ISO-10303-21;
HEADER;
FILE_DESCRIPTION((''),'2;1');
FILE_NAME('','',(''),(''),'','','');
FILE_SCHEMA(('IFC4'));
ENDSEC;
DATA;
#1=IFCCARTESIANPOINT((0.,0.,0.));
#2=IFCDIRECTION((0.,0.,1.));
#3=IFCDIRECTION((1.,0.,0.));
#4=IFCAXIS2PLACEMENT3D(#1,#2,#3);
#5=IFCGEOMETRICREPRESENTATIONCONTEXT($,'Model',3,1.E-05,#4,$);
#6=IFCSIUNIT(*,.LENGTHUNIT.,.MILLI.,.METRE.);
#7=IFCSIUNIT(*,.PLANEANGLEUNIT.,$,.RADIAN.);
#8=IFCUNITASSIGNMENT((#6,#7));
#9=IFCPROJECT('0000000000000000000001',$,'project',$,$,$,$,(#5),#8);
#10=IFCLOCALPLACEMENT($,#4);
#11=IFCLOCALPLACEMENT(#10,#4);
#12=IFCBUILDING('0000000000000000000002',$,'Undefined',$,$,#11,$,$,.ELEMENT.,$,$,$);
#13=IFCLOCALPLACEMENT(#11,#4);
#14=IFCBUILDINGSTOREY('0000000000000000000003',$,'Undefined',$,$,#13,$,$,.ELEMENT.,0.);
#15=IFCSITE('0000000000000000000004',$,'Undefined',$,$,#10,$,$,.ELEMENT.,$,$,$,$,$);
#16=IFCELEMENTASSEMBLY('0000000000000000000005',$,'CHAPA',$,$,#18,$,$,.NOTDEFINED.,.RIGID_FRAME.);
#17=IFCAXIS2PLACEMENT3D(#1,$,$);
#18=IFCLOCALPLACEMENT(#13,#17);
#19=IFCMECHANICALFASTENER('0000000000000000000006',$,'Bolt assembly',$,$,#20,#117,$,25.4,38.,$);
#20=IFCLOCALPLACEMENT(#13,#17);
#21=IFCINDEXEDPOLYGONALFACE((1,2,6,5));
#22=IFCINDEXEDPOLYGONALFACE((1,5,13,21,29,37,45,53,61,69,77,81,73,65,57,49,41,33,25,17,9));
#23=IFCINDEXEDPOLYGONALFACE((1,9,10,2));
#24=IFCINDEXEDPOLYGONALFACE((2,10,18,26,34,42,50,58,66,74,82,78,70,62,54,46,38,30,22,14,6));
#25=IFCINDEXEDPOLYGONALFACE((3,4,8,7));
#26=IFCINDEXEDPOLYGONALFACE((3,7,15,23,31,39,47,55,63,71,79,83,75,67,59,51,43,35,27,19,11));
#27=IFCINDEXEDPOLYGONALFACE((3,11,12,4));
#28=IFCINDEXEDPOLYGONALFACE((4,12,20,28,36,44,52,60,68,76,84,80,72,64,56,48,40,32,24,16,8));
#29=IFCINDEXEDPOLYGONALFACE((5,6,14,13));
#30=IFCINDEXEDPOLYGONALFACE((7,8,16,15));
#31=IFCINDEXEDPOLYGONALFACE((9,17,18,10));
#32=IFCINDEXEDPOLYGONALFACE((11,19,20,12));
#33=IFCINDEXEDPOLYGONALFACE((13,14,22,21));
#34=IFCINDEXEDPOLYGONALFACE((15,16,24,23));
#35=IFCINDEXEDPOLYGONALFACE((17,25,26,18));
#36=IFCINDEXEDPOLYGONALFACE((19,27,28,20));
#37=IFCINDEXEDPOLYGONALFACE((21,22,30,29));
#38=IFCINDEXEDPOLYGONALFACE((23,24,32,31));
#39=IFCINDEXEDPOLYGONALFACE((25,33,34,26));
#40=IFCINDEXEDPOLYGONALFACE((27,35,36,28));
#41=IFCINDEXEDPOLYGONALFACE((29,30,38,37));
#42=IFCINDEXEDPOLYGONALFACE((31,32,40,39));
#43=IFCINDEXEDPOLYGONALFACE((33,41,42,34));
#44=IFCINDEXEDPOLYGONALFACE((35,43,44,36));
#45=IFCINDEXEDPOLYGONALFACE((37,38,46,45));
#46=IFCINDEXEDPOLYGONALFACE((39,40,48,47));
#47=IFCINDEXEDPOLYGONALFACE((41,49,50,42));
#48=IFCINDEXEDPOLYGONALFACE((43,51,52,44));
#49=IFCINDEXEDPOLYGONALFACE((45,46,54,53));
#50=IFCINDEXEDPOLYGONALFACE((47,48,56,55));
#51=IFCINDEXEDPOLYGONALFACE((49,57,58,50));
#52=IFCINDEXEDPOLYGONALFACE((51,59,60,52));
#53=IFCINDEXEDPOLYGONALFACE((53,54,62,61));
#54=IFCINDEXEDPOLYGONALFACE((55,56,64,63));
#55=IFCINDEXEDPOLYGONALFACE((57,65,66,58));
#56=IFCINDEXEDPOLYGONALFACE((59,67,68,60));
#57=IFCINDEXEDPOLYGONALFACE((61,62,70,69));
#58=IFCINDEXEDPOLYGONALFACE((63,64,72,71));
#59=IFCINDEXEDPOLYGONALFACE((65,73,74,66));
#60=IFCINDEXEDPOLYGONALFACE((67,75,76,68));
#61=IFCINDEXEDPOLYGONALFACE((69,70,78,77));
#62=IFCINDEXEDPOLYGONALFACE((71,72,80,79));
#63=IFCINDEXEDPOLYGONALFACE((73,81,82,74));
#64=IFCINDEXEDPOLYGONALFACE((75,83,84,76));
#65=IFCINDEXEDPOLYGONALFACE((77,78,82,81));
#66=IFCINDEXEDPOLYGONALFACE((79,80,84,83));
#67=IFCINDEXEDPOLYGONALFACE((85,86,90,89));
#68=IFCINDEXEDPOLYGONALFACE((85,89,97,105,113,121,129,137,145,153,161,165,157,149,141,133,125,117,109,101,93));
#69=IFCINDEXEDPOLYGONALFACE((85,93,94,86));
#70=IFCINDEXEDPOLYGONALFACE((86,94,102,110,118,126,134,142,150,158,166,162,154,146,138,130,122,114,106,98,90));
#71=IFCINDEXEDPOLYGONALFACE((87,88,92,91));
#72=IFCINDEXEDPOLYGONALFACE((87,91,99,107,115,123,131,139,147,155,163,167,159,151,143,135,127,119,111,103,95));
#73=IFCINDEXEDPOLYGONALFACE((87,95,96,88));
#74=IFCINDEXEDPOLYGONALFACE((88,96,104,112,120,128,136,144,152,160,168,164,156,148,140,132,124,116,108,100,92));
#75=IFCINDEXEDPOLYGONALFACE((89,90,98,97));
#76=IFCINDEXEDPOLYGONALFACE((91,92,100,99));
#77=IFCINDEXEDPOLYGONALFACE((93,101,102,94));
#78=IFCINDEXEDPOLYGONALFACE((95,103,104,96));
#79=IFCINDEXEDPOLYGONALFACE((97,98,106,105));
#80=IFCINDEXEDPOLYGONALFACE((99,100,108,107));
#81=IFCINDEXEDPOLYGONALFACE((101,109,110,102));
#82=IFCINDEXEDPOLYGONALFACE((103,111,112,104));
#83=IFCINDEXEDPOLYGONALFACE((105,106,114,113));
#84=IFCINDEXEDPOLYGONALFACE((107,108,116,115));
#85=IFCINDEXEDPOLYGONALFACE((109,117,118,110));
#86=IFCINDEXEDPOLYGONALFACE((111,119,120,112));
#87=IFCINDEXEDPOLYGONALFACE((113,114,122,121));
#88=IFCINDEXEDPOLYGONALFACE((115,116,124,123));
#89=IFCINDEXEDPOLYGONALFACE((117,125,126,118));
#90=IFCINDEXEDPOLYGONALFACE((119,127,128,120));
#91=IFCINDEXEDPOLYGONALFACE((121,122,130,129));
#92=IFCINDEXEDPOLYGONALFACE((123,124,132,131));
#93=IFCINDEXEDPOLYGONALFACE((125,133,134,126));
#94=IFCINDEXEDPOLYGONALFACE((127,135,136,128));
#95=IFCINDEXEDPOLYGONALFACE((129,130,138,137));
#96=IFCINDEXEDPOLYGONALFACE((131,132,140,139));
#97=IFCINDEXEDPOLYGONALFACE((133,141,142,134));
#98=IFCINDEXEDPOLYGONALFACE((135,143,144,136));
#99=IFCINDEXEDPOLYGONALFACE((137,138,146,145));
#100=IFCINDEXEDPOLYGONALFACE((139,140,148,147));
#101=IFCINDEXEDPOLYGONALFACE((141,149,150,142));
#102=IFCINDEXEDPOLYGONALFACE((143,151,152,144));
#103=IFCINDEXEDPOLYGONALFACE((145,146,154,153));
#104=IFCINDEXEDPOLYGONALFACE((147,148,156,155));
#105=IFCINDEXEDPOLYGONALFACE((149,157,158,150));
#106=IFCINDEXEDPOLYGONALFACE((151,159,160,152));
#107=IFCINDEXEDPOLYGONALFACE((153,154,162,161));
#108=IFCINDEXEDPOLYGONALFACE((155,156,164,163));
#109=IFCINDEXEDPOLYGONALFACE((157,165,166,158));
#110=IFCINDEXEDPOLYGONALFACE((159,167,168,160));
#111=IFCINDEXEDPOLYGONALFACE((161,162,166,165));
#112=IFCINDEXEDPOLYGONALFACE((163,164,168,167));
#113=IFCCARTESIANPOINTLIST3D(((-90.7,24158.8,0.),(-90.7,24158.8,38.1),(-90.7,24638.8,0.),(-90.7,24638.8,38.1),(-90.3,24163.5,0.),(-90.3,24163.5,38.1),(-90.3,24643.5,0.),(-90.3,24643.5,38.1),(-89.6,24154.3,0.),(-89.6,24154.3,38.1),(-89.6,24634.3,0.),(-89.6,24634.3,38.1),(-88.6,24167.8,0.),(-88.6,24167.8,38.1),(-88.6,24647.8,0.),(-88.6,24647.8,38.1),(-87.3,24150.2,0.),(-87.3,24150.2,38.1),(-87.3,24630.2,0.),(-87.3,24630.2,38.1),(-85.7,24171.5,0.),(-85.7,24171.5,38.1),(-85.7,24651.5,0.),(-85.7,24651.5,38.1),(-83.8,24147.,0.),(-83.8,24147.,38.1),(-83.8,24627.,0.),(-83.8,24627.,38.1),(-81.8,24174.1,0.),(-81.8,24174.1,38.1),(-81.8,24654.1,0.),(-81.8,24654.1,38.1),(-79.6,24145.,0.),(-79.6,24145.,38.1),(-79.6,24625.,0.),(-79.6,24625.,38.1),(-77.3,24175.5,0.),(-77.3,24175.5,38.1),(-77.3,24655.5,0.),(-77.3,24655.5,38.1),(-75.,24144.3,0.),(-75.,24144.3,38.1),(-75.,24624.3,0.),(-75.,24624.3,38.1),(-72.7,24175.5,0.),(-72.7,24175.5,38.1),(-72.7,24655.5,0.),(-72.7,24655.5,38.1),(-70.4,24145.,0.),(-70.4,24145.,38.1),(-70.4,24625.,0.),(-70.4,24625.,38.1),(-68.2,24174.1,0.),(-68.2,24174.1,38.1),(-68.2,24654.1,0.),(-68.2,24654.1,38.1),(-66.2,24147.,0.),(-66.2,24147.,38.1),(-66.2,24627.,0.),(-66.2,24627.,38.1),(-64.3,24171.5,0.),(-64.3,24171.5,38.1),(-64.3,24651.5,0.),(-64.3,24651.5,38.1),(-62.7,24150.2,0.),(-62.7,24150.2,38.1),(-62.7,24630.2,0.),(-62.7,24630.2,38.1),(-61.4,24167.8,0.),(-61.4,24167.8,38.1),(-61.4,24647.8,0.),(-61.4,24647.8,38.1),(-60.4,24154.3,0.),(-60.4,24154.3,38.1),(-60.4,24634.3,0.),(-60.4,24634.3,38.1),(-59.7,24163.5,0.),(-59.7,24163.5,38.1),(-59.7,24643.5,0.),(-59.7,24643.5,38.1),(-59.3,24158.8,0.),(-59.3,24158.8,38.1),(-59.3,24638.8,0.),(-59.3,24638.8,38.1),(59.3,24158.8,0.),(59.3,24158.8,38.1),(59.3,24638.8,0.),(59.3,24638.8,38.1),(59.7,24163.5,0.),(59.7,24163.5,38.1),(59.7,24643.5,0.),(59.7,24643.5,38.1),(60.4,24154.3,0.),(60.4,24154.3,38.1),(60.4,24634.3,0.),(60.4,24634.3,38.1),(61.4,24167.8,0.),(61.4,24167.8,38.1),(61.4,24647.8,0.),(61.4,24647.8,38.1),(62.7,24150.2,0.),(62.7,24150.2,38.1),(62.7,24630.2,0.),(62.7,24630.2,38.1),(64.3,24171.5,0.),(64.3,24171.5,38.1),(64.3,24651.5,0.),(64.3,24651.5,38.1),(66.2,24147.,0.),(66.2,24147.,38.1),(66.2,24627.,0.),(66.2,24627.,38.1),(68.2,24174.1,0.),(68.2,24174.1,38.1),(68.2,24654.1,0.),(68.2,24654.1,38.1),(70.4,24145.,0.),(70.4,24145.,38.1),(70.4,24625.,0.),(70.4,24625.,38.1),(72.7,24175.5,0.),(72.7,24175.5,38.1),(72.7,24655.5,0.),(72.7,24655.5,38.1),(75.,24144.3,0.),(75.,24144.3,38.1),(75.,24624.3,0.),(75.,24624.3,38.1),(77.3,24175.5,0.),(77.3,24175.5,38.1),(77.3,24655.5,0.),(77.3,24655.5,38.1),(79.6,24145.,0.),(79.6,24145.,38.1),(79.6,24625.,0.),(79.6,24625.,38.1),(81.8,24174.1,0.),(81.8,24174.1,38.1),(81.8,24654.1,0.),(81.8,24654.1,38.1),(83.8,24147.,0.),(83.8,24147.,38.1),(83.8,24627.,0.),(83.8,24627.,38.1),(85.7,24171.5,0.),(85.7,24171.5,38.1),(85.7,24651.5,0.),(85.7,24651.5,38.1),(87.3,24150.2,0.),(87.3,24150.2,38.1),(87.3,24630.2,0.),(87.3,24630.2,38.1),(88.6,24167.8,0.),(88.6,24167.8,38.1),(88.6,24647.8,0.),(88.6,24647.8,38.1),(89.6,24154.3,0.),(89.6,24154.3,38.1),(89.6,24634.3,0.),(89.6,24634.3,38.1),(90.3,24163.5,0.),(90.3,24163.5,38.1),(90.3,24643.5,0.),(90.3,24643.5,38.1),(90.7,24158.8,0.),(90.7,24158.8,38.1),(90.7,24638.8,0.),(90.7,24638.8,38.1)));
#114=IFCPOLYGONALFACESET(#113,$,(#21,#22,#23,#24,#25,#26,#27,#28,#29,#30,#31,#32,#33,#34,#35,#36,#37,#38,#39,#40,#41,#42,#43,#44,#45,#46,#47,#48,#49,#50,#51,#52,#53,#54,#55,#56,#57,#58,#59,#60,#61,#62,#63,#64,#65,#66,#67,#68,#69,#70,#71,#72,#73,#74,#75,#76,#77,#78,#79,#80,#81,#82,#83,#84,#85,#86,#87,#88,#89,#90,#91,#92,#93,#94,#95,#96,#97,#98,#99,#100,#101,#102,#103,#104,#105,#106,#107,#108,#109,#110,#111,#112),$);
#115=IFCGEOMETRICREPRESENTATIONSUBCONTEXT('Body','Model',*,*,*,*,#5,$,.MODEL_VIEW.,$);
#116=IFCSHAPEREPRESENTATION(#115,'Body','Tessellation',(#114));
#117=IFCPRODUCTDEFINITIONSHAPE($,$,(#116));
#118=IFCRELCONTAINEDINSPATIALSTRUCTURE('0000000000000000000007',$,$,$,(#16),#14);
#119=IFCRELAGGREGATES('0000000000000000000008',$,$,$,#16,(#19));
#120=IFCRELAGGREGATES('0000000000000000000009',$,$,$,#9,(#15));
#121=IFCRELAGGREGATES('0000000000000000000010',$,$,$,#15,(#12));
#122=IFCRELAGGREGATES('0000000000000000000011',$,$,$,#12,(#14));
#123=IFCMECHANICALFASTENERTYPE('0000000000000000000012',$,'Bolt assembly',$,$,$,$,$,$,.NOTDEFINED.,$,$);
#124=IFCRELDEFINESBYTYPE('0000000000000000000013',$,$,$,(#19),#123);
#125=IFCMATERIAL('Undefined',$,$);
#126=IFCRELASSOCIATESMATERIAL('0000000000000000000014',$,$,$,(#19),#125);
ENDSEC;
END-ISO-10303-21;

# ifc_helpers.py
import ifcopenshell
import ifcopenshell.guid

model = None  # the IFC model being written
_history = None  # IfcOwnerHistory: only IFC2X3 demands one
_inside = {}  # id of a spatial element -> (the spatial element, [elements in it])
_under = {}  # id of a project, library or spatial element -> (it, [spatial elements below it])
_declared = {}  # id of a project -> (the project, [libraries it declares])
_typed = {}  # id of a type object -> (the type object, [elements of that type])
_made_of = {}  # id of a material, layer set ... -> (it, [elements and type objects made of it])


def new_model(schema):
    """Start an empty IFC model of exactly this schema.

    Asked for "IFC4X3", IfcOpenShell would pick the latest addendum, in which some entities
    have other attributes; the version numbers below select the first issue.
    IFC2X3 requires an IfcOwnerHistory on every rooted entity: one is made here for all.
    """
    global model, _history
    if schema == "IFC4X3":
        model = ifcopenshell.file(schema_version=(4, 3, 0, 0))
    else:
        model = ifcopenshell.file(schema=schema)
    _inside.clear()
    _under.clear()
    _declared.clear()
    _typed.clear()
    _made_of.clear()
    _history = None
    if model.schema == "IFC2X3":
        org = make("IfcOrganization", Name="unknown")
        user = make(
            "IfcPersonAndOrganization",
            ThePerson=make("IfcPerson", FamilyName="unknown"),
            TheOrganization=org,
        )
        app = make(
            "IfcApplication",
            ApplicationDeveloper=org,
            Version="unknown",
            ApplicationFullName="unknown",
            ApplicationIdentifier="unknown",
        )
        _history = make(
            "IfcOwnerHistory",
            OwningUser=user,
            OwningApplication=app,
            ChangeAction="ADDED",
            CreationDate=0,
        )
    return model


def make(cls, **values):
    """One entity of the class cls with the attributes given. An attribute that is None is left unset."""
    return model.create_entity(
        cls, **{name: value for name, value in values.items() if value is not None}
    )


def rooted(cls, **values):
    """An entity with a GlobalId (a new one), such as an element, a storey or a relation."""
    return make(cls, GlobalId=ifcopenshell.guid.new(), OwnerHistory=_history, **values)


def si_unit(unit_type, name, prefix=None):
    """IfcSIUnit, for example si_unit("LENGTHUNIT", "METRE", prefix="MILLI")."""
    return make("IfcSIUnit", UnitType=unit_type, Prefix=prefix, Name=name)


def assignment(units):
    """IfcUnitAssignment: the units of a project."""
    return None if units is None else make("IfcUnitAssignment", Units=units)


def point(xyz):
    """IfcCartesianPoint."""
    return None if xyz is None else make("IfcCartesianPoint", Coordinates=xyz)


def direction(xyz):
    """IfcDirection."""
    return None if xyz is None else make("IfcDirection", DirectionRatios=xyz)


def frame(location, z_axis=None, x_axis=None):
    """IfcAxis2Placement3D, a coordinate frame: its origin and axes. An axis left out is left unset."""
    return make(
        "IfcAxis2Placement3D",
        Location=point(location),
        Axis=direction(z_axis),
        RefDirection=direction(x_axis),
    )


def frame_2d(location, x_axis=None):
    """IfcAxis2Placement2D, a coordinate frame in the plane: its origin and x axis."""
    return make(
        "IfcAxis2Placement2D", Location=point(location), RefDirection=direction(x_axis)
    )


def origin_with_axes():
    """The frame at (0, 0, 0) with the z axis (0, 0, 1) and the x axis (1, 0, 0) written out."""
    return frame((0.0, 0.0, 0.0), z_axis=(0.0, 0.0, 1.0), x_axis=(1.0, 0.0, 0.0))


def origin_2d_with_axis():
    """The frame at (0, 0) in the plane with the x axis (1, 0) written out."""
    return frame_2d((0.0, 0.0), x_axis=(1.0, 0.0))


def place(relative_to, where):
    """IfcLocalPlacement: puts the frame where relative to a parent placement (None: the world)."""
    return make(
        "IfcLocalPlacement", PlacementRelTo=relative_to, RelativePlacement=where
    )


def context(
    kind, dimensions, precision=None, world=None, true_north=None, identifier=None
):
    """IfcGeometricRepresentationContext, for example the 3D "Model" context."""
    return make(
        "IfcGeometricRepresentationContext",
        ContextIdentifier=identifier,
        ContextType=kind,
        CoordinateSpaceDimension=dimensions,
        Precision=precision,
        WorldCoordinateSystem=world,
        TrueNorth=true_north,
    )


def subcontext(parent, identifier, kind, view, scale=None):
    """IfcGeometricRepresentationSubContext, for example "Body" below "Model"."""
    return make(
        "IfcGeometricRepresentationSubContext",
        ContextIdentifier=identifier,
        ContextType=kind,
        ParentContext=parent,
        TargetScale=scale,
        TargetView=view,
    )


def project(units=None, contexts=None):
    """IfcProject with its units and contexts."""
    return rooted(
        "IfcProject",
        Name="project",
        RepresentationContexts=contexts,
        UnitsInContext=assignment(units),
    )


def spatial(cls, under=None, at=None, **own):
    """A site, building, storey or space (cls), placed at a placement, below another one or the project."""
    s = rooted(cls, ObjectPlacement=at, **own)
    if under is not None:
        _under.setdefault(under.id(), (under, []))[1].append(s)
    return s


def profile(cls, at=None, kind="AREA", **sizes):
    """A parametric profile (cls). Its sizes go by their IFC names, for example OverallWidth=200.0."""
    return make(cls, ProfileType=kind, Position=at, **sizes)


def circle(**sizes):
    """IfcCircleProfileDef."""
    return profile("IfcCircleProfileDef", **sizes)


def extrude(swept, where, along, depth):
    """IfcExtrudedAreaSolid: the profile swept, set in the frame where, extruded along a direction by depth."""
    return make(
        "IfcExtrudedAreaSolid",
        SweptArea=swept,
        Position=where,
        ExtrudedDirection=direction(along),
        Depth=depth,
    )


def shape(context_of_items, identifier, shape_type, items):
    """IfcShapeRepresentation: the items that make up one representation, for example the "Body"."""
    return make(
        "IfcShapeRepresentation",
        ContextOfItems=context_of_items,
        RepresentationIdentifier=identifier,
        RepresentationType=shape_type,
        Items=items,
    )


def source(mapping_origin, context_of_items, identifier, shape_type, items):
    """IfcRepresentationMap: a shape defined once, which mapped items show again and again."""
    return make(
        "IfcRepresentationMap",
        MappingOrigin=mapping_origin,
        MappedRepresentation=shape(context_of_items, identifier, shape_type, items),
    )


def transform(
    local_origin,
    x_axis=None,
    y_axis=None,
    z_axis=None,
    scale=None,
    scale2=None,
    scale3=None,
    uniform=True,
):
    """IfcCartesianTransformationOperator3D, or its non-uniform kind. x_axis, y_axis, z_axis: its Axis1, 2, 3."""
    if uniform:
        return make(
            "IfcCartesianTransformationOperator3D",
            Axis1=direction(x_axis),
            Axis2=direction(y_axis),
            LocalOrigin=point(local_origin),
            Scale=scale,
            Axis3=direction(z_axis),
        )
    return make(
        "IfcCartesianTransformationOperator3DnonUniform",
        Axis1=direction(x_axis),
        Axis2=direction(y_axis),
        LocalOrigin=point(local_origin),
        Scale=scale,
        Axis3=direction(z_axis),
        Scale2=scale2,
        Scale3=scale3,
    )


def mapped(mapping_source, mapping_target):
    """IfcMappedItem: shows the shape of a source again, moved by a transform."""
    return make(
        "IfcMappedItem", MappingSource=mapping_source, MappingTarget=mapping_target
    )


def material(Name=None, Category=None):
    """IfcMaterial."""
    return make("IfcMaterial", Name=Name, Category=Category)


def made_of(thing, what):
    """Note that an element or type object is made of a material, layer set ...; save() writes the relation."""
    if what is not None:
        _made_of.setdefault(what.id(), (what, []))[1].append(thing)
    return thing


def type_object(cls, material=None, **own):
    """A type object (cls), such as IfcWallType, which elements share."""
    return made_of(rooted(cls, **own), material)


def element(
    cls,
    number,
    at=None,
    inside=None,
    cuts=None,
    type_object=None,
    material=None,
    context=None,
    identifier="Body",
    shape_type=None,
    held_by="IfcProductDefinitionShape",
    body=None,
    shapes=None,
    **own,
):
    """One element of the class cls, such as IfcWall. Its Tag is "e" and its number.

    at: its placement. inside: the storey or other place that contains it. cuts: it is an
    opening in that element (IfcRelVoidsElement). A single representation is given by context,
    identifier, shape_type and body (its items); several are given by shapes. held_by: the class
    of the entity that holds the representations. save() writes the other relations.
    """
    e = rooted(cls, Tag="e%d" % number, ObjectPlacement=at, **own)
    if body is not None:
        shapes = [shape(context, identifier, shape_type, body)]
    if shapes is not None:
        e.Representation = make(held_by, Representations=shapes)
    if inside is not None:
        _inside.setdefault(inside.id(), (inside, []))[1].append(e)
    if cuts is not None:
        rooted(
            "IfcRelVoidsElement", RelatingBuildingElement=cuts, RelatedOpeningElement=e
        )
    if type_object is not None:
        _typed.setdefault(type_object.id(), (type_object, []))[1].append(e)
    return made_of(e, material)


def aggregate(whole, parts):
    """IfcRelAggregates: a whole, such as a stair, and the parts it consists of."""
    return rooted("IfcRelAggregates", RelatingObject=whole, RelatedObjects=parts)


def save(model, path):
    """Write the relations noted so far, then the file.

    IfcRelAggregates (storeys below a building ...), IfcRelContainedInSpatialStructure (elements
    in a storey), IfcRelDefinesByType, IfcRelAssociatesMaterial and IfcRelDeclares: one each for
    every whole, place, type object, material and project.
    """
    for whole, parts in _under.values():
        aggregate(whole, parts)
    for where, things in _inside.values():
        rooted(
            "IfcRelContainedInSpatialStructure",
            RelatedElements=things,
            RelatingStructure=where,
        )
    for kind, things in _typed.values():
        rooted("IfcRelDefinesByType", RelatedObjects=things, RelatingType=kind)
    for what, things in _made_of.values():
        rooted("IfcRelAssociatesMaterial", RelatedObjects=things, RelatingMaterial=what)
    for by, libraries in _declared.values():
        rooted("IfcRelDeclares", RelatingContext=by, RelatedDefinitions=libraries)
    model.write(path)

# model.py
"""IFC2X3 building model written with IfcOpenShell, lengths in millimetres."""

from ifc_helpers import new_model, si_unit, frame, origin_with_axes, origin_2d_with_axis, place, context, subcontext, project, spatial, circle, extrude, source, transform, mapped, material, type_object, element, aggregate, save


model = new_model("IFC2X3")

# Units and contexts
model_context = context("Model", 3, precision=1e-05, world=origin_with_axes())
body_context = subcontext(model_context, "Body", "Model", "MODEL_VIEW")
ifc_project = project(units=[si_unit("LENGTHUNIT", "METRE", prefix="MILLI"), si_unit("PLANEANGLEUNIT", "RADIAN")], contexts=[model_context])

# Site, building, storey
site_placement = place(None, origin_with_axes())
site = spatial("IfcSite", under=ifc_project, at=site_placement, Name="Undefined", CompositionType="ELEMENT")
building_placement = place(site_placement, origin_with_axes())
building = spatial("IfcBuilding", under=site, at=building_placement, Name="Undefined", CompositionType="ELEMENT")
storey_placement = place(building_placement, origin_with_axes())
storey = spatial("IfcBuildingStorey", under=building, at=storey_placement, Name="Undefined", CompositionType="ELEMENT", Elevation=0.0)

# Element assembly
assembly_1_placement = place(storey_placement, origin_with_axes())
assembly_1 = element("IfcElementAssembly", 1, at=assembly_1_placement, inside=storey, Name="CHAPA", AssemblyPlace="NOTDEFINED", PredefinedType="RIGID_FRAME")

# Shared definitions
ifc_material_1 = material(Name="Undefined")
mechanical_fastener_type = type_object("IfcMechanicalFastenerType", Name="Bolt assembly")

# Mechanical fastener
shared_shape_1 = source(origin_with_axes(), body_context, "Body", "SweptSolid", [
    extrude(circle(Radius=15.7, at=origin_2d_with_axis()), frame((0.0, -38.0, 0.0), z_axis=(0.0, 1.0, 0.0), x_axis=(1.0, 0.0, 0.0)), (0.0, 0.0, 1.0), 38.1),
])
mechanical_fastener_1_placement = place(assembly_1_placement, frame((0.0, 24640.0, 38.0), z_axis=(-1.0, 0.0, 0.0), x_axis=(0.0, -1.0, 0.0)))
mechanical_fastener_1 = element("IfcMechanicalFastener", 2, at=mechanical_fastener_1_placement, type_object=mechanical_fastener_type, material=ifc_material_1, Name="Bolt assembly", NominalDiameter=25.4, NominalLength=38.0, context=body_context, shape_type="MappedRepresentation", body=[
    mapped(shared_shape_1, transform((0.0, 0.0, -75.0))),
    mapped(shared_shape_1, transform((0.0, 0.0, 75.0))),
    mapped(shared_shape_1, transform((480.0, 0.0, -75.0))),
    mapped(shared_shape_1, transform((480.0, 0.0, 75.0))),
])
aggregate(assembly_1, [mechanical_fastener_1])

save(model, "model.ifc")
